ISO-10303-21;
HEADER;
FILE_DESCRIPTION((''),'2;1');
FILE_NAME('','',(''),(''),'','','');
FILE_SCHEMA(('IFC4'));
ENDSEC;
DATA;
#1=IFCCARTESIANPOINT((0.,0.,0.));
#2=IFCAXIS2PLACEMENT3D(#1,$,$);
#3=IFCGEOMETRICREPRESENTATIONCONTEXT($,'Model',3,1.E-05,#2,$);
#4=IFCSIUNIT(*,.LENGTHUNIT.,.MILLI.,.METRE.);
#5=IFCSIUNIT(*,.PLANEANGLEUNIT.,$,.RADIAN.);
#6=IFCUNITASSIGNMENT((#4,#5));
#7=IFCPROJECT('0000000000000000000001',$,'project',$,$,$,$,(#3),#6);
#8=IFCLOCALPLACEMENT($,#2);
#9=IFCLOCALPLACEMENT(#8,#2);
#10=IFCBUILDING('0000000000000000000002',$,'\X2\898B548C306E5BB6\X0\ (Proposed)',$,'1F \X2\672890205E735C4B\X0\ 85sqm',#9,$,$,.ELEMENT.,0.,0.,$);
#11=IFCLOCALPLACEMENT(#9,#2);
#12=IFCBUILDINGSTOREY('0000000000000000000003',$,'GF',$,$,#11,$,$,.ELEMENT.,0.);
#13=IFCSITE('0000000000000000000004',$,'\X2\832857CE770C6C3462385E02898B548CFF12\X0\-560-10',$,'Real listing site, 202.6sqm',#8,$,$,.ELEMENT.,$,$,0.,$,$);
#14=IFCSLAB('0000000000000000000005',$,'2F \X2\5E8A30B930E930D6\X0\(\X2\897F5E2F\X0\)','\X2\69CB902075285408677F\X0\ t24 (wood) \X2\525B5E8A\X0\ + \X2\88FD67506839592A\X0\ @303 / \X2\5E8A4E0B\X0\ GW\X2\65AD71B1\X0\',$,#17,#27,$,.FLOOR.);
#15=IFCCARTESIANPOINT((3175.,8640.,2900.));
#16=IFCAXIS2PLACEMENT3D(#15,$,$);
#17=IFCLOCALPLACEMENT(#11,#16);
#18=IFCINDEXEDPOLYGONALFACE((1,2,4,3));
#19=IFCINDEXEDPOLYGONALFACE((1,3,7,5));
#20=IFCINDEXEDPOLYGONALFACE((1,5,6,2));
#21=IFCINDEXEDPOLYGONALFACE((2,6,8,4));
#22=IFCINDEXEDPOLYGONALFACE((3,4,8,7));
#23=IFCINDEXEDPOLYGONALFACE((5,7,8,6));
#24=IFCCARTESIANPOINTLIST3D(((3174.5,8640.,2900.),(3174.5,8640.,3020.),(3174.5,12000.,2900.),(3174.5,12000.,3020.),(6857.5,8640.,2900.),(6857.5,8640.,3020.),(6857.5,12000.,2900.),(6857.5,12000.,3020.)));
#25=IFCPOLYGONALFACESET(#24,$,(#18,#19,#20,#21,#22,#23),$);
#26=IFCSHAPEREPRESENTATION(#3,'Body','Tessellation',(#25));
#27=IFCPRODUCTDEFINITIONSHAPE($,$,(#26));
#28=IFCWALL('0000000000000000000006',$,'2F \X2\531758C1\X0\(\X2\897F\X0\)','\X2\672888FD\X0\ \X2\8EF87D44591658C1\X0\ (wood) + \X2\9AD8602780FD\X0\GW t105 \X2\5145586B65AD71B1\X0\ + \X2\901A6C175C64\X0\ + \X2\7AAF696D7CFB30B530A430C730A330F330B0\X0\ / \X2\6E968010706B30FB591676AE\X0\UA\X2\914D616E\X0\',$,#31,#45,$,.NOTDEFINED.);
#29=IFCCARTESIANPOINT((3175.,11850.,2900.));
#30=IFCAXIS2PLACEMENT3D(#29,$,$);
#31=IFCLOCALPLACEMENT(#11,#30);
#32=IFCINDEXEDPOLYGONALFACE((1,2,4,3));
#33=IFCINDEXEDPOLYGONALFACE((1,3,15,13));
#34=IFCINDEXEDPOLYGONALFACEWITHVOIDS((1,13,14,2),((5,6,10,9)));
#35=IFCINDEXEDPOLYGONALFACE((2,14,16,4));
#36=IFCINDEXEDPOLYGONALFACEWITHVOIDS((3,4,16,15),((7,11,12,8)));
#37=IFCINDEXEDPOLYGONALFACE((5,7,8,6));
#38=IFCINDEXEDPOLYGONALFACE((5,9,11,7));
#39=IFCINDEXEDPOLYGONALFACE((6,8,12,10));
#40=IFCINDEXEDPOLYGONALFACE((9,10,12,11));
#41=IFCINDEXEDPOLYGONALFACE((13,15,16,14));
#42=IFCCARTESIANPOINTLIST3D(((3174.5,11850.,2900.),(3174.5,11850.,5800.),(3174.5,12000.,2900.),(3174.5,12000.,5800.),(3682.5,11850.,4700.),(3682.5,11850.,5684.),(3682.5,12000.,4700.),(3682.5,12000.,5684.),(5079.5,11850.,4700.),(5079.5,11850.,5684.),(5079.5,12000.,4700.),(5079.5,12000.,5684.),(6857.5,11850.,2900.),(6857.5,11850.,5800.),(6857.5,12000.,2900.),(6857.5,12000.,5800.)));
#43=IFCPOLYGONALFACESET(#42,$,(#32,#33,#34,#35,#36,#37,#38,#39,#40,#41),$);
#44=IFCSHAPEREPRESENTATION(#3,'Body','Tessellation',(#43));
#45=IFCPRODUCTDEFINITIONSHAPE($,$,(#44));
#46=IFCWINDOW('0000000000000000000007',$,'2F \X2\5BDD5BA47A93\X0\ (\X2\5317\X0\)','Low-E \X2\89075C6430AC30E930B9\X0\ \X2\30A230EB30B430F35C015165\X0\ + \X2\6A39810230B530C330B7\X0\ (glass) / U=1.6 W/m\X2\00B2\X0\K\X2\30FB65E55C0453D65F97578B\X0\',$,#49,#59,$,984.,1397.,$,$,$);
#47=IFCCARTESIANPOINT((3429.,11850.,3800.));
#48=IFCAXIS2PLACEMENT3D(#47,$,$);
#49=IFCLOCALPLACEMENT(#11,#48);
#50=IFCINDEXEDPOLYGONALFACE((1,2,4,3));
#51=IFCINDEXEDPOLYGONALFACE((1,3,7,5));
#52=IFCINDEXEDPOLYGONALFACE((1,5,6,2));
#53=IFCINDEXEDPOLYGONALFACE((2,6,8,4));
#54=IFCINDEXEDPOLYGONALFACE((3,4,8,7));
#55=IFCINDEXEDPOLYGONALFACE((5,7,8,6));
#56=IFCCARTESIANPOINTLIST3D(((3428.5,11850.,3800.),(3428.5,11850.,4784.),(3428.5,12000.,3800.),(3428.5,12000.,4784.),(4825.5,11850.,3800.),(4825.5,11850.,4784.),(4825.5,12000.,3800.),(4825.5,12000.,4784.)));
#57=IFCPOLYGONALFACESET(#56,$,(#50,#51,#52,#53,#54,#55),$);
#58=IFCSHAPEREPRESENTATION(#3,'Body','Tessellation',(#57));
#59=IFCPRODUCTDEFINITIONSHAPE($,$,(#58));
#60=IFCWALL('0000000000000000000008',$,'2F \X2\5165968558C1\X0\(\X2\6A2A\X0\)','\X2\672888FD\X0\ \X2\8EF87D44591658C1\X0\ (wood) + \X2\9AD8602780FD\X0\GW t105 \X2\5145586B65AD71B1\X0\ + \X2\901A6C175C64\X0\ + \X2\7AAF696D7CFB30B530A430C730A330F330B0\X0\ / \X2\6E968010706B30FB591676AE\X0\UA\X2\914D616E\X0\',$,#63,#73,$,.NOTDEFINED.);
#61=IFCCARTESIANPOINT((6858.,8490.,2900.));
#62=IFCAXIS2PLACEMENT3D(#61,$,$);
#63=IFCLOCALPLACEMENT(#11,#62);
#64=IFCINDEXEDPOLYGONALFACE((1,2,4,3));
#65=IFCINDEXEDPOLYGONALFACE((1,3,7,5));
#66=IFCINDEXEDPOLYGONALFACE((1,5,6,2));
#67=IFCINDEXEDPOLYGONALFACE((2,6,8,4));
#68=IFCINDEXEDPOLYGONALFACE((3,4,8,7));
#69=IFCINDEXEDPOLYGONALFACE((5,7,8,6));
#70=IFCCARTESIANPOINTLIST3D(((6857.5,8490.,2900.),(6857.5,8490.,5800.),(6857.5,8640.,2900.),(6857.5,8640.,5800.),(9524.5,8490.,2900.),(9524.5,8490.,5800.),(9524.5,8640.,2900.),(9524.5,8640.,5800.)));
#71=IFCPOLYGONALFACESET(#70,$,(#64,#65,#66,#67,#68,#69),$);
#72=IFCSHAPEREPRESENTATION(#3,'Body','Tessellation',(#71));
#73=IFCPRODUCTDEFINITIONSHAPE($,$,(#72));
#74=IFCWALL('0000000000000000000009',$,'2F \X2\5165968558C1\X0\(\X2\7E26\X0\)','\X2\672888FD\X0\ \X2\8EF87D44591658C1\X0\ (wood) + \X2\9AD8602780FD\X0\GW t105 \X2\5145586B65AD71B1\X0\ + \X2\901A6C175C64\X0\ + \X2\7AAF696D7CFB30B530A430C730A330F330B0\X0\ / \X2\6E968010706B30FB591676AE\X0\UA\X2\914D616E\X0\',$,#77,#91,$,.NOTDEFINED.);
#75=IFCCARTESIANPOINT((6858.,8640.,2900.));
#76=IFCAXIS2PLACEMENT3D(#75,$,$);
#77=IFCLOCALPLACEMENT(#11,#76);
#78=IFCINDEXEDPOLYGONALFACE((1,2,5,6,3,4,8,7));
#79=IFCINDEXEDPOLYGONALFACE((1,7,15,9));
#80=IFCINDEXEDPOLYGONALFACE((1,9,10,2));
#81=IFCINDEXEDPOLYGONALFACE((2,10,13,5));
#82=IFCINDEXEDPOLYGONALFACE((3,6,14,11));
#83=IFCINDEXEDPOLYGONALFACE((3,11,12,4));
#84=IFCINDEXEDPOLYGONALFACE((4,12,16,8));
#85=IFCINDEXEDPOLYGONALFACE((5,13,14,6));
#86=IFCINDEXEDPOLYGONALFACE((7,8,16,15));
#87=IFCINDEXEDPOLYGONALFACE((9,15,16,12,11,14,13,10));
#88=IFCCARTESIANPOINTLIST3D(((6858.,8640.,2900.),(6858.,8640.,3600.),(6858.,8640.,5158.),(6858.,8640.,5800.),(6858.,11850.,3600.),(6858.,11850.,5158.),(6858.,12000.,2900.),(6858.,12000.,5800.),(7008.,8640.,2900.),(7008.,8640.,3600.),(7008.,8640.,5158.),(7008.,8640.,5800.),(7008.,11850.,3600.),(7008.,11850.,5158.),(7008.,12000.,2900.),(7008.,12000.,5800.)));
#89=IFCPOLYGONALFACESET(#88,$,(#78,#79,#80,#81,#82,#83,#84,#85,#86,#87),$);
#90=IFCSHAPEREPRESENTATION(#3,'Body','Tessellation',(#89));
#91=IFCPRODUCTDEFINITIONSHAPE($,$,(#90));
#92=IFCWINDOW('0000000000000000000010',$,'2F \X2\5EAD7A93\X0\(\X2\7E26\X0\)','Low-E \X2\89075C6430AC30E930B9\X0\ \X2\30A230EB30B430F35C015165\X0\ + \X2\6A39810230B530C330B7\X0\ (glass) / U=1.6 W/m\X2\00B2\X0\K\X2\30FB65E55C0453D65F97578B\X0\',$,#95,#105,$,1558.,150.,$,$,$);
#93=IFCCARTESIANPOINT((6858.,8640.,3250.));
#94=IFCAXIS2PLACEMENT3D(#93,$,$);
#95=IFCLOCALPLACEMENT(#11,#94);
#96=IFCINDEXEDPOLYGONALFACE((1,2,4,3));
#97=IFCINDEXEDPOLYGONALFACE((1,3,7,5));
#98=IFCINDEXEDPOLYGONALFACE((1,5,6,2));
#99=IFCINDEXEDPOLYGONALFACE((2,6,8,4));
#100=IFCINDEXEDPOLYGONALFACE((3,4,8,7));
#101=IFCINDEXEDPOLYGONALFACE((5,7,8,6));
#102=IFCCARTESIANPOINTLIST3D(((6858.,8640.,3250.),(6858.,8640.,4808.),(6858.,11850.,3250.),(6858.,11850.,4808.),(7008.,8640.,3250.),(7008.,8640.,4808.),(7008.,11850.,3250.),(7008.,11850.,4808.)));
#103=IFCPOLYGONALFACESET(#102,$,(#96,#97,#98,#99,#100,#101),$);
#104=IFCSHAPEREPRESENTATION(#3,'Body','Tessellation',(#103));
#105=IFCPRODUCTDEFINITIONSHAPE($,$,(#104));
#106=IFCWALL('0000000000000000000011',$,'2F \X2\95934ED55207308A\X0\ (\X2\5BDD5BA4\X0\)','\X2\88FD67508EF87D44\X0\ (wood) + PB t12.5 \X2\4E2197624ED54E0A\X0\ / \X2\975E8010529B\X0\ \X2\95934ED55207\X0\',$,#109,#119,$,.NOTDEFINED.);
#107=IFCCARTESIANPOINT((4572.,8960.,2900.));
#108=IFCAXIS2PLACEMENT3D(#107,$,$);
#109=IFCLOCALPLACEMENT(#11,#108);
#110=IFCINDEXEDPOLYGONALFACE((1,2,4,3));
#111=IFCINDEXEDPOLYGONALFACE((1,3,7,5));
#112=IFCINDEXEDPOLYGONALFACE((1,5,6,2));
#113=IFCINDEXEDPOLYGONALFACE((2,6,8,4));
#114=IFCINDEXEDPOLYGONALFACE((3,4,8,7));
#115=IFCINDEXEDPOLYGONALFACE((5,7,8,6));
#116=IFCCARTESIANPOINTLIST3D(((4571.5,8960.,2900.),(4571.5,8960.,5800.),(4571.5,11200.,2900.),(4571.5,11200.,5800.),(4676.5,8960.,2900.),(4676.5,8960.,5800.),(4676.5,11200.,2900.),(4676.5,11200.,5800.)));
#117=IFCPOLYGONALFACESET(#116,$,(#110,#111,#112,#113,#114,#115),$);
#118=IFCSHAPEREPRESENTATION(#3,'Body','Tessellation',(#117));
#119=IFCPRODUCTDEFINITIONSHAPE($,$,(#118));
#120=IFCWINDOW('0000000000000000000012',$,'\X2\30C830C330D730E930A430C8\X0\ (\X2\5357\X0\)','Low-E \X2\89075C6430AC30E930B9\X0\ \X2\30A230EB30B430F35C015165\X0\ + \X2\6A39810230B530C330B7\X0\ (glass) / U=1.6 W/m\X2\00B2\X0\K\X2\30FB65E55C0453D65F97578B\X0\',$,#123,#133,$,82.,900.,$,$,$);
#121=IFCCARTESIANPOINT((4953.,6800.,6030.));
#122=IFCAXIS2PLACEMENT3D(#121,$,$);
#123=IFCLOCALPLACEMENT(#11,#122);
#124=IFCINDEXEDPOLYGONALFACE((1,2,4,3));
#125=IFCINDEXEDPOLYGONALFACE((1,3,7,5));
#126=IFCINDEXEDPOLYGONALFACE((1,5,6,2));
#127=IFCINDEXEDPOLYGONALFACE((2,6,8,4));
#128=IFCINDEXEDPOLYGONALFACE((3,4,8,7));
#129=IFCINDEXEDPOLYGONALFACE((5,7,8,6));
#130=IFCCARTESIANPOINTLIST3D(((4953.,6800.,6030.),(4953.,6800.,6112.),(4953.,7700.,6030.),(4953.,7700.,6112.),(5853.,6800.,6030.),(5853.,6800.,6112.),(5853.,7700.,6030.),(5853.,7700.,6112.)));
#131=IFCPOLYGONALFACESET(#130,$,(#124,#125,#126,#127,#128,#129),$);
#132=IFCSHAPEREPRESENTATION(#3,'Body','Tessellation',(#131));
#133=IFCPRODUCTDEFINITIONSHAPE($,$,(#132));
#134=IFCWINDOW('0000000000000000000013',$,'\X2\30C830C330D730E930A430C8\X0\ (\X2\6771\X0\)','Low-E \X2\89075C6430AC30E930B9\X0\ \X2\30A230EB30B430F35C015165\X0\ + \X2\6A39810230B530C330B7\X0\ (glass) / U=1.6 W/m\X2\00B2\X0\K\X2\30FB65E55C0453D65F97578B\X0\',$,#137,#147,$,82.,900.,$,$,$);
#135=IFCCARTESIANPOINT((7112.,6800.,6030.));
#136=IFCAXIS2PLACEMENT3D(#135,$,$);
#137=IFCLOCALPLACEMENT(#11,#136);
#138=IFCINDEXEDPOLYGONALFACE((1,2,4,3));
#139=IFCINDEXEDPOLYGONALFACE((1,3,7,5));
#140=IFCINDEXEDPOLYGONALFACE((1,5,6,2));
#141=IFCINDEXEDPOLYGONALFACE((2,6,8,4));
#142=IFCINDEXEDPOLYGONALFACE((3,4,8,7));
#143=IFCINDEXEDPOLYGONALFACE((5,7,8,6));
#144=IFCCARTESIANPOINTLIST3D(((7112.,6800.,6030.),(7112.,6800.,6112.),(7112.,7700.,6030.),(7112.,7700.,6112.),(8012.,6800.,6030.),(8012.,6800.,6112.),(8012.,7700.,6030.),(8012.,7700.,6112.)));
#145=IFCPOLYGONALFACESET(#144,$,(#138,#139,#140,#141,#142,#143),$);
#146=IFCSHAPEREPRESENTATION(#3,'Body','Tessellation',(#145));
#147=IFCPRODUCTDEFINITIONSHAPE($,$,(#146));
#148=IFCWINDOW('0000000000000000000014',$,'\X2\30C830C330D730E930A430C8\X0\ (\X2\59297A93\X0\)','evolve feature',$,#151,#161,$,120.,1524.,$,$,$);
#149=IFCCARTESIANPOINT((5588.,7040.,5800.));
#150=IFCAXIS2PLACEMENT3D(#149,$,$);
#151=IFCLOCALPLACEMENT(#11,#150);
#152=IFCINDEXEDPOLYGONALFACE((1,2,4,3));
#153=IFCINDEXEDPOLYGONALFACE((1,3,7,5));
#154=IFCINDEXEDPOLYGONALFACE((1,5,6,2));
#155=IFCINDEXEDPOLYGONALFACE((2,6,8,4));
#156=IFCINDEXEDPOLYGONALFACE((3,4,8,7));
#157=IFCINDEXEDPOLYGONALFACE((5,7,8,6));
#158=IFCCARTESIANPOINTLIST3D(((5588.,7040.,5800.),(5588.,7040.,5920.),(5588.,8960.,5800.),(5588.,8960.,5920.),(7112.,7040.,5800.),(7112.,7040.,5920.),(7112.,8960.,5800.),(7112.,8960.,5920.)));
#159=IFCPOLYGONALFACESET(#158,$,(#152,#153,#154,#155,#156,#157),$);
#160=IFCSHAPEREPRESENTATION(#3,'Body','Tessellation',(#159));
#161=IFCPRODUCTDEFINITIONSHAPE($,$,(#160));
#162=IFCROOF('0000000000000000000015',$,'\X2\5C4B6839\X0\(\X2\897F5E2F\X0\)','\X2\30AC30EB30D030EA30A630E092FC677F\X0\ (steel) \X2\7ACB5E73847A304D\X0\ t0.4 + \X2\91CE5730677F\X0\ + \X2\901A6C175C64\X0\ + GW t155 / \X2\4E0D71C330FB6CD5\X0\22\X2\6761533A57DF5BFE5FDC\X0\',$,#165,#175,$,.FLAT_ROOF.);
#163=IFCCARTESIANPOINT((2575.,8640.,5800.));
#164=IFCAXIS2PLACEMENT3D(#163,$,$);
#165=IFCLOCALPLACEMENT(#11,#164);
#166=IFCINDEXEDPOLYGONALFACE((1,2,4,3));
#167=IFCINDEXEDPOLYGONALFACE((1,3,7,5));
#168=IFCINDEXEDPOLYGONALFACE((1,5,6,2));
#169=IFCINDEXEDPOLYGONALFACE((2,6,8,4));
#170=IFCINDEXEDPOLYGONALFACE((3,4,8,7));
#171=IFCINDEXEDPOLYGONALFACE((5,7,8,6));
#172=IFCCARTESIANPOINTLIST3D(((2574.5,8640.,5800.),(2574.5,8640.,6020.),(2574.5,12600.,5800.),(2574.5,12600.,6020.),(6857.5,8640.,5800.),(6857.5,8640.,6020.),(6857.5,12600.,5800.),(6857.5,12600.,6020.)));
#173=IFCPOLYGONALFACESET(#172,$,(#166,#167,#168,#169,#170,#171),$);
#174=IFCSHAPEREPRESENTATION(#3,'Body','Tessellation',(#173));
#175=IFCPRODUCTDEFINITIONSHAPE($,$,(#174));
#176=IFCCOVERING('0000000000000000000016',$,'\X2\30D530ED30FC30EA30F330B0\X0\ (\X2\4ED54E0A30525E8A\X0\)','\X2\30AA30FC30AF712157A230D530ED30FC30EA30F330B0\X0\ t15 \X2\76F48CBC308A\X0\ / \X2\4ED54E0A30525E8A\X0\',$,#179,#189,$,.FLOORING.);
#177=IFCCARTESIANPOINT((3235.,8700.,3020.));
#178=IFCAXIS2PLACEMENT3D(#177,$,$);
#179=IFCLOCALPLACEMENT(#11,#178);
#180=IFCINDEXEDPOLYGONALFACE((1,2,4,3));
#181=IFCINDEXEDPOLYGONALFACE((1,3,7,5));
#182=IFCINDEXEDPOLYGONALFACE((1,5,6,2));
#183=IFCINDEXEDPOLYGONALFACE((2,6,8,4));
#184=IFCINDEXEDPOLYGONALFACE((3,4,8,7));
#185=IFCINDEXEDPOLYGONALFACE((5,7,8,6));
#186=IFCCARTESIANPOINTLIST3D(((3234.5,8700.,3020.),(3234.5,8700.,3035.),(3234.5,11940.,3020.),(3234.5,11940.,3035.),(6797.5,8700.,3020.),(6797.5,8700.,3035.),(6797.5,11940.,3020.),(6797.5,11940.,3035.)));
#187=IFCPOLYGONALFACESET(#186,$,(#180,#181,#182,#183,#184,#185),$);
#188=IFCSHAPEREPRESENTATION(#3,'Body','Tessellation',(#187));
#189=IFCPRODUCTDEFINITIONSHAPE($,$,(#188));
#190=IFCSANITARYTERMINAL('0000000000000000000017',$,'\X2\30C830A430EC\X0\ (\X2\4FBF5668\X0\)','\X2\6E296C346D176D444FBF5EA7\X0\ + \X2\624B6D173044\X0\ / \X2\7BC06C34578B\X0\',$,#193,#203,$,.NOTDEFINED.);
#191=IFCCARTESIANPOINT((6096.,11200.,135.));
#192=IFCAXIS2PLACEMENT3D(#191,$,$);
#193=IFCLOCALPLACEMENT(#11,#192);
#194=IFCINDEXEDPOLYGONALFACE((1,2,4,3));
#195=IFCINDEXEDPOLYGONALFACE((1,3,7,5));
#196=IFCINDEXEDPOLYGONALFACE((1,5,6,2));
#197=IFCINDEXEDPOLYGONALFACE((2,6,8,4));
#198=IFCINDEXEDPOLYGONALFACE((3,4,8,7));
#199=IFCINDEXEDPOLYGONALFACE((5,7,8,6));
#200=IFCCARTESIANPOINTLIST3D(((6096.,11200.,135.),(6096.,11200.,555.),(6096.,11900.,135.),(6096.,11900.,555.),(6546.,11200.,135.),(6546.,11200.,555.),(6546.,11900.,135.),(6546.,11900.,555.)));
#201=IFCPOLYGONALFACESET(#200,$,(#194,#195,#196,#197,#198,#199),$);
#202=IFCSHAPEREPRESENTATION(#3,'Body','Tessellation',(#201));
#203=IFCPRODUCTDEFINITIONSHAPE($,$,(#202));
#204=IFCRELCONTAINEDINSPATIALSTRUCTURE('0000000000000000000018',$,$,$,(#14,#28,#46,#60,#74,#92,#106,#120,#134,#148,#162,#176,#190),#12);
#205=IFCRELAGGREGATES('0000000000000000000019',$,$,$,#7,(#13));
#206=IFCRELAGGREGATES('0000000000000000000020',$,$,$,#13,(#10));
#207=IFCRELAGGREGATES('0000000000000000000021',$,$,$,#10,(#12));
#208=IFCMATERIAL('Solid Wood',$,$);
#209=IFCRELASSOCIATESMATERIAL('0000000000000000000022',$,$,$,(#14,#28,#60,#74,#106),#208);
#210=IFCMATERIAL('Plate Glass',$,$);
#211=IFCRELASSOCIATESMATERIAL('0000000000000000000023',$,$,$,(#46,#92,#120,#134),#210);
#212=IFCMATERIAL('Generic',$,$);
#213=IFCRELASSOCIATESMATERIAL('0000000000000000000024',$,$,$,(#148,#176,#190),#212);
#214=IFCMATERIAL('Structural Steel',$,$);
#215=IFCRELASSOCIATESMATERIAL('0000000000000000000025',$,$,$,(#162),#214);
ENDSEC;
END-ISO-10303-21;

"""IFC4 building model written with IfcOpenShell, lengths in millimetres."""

from ifc_helpers import new_model, si_unit, frame, frame_2d, origin, place, context, project, spatial, rectangle, extrude, material, element, fill, save


model = new_model("IFC4")

# Units and contexts
model_context = context("Model", 3, precision=1e-05, world=origin())
ifc_project = project(units=[si_unit("LENGTHUNIT", "METRE", prefix="MILLI"), si_unit("PLANEANGLEUNIT", "RADIAN")], contexts=[model_context])

# Site, building, storey
site_placement = place(None, origin())
site = spatial("IfcSite", under=ifc_project, at=site_placement, Name="茨城県水戸市見和２-560-10", ObjectType="Real listing site, 202.6sqm", CompositionType="ELEMENT", RefElevation=0.0)
building_placement = place(site_placement, origin())
building = spatial("IfcBuilding", under=site, at=building_placement, Name="見和の家 (Proposed)", ObjectType="1F 木造平屋 85sqm", CompositionType="ELEMENT", ElevationOfRefHeight=0.0, ElevationOfTerrain=0.0)
storey_placement = place(building_placement, origin())
storey = spatial("IfcBuildingStorey", under=building, at=storey_placement, Name="GF", CompositionType="ELEMENT", Elevation=0.0)

# Slab
ifc_material_1 = material(Name="Solid Wood")
slab_placement = place(storey_placement, frame((3175.0, 8640.0, 2900.0)))
element("IfcSlab", 1, at=slab_placement, inside=storey, material=ifc_material_1, Name="2F 床スラブ(西帯)", Description="構造用合板 t24 (wood) 剛床 + 製材根太 @303 / 床下 GW断熱", PredefinedType="FLOOR", context=model_context, shape_type="SweptSolid", body=[
    extrude(rectangle(XDim=3683.0, YDim=3360.0, at=frame_2d((1841.0, 1680.0))), frame((3175.0, 8640.0, 2900.0)), (0.0, 0.0, 1.0), 120.0),
])

# Wall, opening, window
wall_1_placement = place(storey_placement, frame((3175.0, 11850.0, 2900.0)))
wall_1 = element("IfcWall", 2, at=wall_1_placement, inside=storey, material=ifc_material_1, Name="2F 北壁(西)", Description="木製 軸組外壁 (wood) + 高性能GW t105 充填断熱 + 通気層 + 窯業系サイディング / 準耐火・外皮UA配慮", PredefinedType="NOTDEFINED", context=model_context, shape_type="SweptSolid", body=[
    extrude(rectangle(XDim=3683.0, YDim=150.0, at=frame_2d((1841.0, 75.0))), frame((3175.0, 11850.0, 2900.0)), (0.0, 0.0, 1.0), 2900.0),
])
opening_1_placement = place(storey_placement, frame((3429.0, 11850.0, 3800.0)))
opening_1 = element("IfcOpeningElement", 3, at=opening_1_placement, cuts=wall_1, PredefinedType="NOTDEFINED", context=model_context, shape_type="SweptSolid", body=[
    extrude(rectangle(XDim=1397.0, YDim=150.0, at=frame_2d((698.0, 75.0))), frame((3429.0, 11850.0, 3800.0)), (0.0, 0.0, 1.0), 984.0),
])
ifc_material_2 = material(Name="Plate Glass")
window_1_placement = place(storey_placement, frame((3429.0, 11850.0, 3800.0)))
window_1 = element("IfcWindow", 4, at=window_1_placement, inside=storey, material=ifc_material_2, Name="2F 寝室窓 (北)", Description="Low-E 複層ガラス アルゴン封入 + 樹脂サッシ (glass) / U=1.6 W/m²K・日射取得型", OverallHeight=984.0, OverallWidth=1397.0, context=model_context, shape_type="SweptSolid", body=[
    extrude(rectangle(XDim=1397.0, YDim=150.0, at=frame_2d((698.0, 75.0))), frame((3429.0, 11850.0, 3800.0)), (0.0, 0.0, 1.0), 984.0),
])
fill(opening_1, window_1)

# Wall
wall_2_placement = place(storey_placement, frame((6858.0, 8490.0, 2900.0)))
element("IfcWall", 5, at=wall_2_placement, inside=storey, material=ifc_material_1, Name="2F 入隅壁(横)", Description="木製 軸組外壁 (wood) + 高性能GW t105 充填断熱 + 通気層 + 窯業系サイディング / 準耐火・外皮UA配慮", PredefinedType="NOTDEFINED", context=model_context, shape_type="SweptSolid", body=[
    extrude(rectangle(XDim=2667.0, YDim=150.0, at=frame_2d((1333.0, 75.0))), frame((6858.0, 8490.0, 2900.0)), (0.0, 0.0, 1.0), 2900.0),
])

# Wall, opening, window
wall_3_placement = place(storey_placement, frame((6858.0, 8640.0, 2900.0)))
wall_3 = element("IfcWall", 6, at=wall_3_placement, inside=storey, material=ifc_material_1, Name="2F 入隅壁(縦)", Description="木製 軸組外壁 (wood) + 高性能GW t105 充填断熱 + 通気層 + 窯業系サイディング / 準耐火・外皮UA配慮", PredefinedType="NOTDEFINED", context=model_context, shape_type="SweptSolid", body=[
    extrude(rectangle(XDim=150.0, YDim=3360.0, at=frame_2d((75.0, 1680.0))), frame((6858.0, 8640.0, 2900.0)), (0.0, 0.0, 1.0), 2900.0),
])
opening_2_placement = place(storey_placement, frame((6858.0, 8640.0, 3250.0)))
opening_2 = element("IfcOpeningElement", 7, at=opening_2_placement, cuts=wall_3, PredefinedType="NOTDEFINED", context=model_context, shape_type="SweptSolid", body=[
    extrude(rectangle(XDim=150.0, YDim=3210.0, at=frame_2d((75.0, 1605.0))), frame((6858.0, 8640.0, 3250.0)), (0.0, 0.0, 1.0), 1558.0),
])
window_2_placement = place(storey_placement, frame((6858.0, 8640.0, 3250.0)))
window_2 = element("IfcWindow", 8, at=window_2_placement, inside=storey, material=ifc_material_2, Name="2F 庭窓(縦)", Description="Low-E 複層ガラス アルゴン封入 + 樹脂サッシ (glass) / U=1.6 W/m²K・日射取得型", OverallHeight=1558.0, OverallWidth=150.0, context=model_context, shape_type="SweptSolid", body=[
    extrude(rectangle(XDim=150.0, YDim=3210.0, at=frame_2d((75.0, 1605.0))), frame((6858.0, 8640.0, 3250.0)), (0.0, 0.0, 1.0), 1558.0),
])
fill(opening_2, window_2)

# Wall
wall_4_placement = place(storey_placement, frame((4572.0, 8960.0, 2900.0)))
element("IfcWall", 9, at=wall_4_placement, inside=storey, material=ifc_material_1, Name="2F 間仕切り (寝室)", Description="製材軸組 (wood) + PB t12.5 両面仕上 / 非耐力 間仕切", PredefinedType="NOTDEFINED", context=model_context, shape_type="SweptSolid", body=[
    extrude(rectangle(XDim=105.0, YDim=2240.0, at=frame_2d((52.0, 1120.0))), frame((4572.0, 8960.0, 2900.0)), (0.0, 0.0, 1.0), 2900.0),
])

# Windows
window_3_placement = place(storey_placement, frame((4953.0, 6800.0, 6030.0)))
element("IfcWindow", 10, at=window_3_placement, inside=storey, material=ifc_material_2, Name="トップライト (南)", Description="Low-E 複層ガラス アルゴン封入 + 樹脂サッシ (glass) / U=1.6 W/m²K・日射取得型", OverallHeight=82.0, OverallWidth=900.0, context=model_context, shape_type="SweptSolid", body=[
    extrude(rectangle(XDim=900.0, YDim=900.0, at=frame_2d((450.0, 450.0))), frame((4953.0, 6800.0, 6030.0)), (0.0, 0.0, 1.0), 82.0),
])
window_4_placement = place(storey_placement, frame((7112.0, 6800.0, 6030.0)))
element("IfcWindow", 11, at=window_4_placement, inside=storey, material=ifc_material_2, Name="トップライト (東)", Description="Low-E 複層ガラス アルゴン封入 + 樹脂サッシ (glass) / U=1.6 W/m²K・日射取得型", OverallHeight=82.0, OverallWidth=900.0, context=model_context, shape_type="SweptSolid", body=[
    extrude(rectangle(XDim=900.0, YDim=900.0, at=frame_2d((450.0, 450.0))), frame((7112.0, 6800.0, 6030.0)), (0.0, 0.0, 1.0), 82.0),
])
ifc_material_3 = material(Name="Generic")
window_5_placement = place(storey_placement, frame((5588.0, 7040.0, 5800.0)))
element("IfcWindow", 12, at=window_5_placement, inside=storey, material=ifc_material_3, Name="トップライト (天窓)", Description="evolve feature", OverallHeight=120.0, OverallWidth=1524.0, context=model_context, shape_type="SweptSolid", body=[
    extrude(rectangle(XDim=1524.0, YDim=1920.0, at=frame_2d((762.0, 960.0))), frame((5588.0, 7040.0, 5800.0)), (0.0, 0.0, 1.0), 120.0),
])

# Roof
ifc_material_4 = material(Name="Structural Steel")
for number, where, name in (
    (13, (2575.0, 8640.0, 5800.0), "屋根(西帯)"),
):
    element("IfcRoof", number, at=place(storey_placement, frame(where)), inside=storey, material=ifc_material_4, Name=name, Description="ガルバリウム鋼板 (steel) 立平葺き t0.4 + 野地板 + 通気層 + GW t155 / 不燃・法22条区域対応", PredefinedType="FLAT_ROOF", context=model_context, shape_type="SweptSolid", body=[
        extrude(rectangle(XDim=4283.0, YDim=3960.0, at=frame_2d((2141.0, 1980.0))), frame((2575.0, 8640.0, 5800.0)), (0.0, 0.0, 1.0), 220.0),
    ])

# Covering
covering_placement = place(storey_placement, frame((3235.0, 8700.0, 3020.0)))
element("IfcCovering", 14, at=covering_placement, inside=storey, material=ifc_material_3, Name="フローリング (仕上げ床)", Description="オーク無垢フローリング t15 直貼り / 仕上げ床", PredefinedType="FLOORING", context=model_context, shape_type="SweptSolid", body=[
    extrude(rectangle(XDim=3563.0, YDim=3240.0, at=frame_2d((1781.0, 1620.0))), frame((3235.0, 8700.0, 3020.0)), (0.0, 0.0, 1.0), 15.0),
])

# Sanitary terminal
sanitary_terminal_placement = place(storey_placement, frame((6096.0, 11200.0, 135.0)))
element("IfcSanitaryTerminal", 15, at=sanitary_terminal_placement, inside=storey, material=ifc_material_3, Name="トイレ (便器)", Description="温水洗浄便座 + 手洗い / 節水型", PredefinedType="NOTDEFINED", context=model_context, shape_type="SweptSolid", body=[
    extrude(rectangle(XDim=450.0, YDim=700.0, at=frame_2d((225.0, 350.0))), frame((6096.0, 11200.0, 135.0)), (0.0, 0.0, 1.0), 420.0),
])

save(model, "model.ifc")
